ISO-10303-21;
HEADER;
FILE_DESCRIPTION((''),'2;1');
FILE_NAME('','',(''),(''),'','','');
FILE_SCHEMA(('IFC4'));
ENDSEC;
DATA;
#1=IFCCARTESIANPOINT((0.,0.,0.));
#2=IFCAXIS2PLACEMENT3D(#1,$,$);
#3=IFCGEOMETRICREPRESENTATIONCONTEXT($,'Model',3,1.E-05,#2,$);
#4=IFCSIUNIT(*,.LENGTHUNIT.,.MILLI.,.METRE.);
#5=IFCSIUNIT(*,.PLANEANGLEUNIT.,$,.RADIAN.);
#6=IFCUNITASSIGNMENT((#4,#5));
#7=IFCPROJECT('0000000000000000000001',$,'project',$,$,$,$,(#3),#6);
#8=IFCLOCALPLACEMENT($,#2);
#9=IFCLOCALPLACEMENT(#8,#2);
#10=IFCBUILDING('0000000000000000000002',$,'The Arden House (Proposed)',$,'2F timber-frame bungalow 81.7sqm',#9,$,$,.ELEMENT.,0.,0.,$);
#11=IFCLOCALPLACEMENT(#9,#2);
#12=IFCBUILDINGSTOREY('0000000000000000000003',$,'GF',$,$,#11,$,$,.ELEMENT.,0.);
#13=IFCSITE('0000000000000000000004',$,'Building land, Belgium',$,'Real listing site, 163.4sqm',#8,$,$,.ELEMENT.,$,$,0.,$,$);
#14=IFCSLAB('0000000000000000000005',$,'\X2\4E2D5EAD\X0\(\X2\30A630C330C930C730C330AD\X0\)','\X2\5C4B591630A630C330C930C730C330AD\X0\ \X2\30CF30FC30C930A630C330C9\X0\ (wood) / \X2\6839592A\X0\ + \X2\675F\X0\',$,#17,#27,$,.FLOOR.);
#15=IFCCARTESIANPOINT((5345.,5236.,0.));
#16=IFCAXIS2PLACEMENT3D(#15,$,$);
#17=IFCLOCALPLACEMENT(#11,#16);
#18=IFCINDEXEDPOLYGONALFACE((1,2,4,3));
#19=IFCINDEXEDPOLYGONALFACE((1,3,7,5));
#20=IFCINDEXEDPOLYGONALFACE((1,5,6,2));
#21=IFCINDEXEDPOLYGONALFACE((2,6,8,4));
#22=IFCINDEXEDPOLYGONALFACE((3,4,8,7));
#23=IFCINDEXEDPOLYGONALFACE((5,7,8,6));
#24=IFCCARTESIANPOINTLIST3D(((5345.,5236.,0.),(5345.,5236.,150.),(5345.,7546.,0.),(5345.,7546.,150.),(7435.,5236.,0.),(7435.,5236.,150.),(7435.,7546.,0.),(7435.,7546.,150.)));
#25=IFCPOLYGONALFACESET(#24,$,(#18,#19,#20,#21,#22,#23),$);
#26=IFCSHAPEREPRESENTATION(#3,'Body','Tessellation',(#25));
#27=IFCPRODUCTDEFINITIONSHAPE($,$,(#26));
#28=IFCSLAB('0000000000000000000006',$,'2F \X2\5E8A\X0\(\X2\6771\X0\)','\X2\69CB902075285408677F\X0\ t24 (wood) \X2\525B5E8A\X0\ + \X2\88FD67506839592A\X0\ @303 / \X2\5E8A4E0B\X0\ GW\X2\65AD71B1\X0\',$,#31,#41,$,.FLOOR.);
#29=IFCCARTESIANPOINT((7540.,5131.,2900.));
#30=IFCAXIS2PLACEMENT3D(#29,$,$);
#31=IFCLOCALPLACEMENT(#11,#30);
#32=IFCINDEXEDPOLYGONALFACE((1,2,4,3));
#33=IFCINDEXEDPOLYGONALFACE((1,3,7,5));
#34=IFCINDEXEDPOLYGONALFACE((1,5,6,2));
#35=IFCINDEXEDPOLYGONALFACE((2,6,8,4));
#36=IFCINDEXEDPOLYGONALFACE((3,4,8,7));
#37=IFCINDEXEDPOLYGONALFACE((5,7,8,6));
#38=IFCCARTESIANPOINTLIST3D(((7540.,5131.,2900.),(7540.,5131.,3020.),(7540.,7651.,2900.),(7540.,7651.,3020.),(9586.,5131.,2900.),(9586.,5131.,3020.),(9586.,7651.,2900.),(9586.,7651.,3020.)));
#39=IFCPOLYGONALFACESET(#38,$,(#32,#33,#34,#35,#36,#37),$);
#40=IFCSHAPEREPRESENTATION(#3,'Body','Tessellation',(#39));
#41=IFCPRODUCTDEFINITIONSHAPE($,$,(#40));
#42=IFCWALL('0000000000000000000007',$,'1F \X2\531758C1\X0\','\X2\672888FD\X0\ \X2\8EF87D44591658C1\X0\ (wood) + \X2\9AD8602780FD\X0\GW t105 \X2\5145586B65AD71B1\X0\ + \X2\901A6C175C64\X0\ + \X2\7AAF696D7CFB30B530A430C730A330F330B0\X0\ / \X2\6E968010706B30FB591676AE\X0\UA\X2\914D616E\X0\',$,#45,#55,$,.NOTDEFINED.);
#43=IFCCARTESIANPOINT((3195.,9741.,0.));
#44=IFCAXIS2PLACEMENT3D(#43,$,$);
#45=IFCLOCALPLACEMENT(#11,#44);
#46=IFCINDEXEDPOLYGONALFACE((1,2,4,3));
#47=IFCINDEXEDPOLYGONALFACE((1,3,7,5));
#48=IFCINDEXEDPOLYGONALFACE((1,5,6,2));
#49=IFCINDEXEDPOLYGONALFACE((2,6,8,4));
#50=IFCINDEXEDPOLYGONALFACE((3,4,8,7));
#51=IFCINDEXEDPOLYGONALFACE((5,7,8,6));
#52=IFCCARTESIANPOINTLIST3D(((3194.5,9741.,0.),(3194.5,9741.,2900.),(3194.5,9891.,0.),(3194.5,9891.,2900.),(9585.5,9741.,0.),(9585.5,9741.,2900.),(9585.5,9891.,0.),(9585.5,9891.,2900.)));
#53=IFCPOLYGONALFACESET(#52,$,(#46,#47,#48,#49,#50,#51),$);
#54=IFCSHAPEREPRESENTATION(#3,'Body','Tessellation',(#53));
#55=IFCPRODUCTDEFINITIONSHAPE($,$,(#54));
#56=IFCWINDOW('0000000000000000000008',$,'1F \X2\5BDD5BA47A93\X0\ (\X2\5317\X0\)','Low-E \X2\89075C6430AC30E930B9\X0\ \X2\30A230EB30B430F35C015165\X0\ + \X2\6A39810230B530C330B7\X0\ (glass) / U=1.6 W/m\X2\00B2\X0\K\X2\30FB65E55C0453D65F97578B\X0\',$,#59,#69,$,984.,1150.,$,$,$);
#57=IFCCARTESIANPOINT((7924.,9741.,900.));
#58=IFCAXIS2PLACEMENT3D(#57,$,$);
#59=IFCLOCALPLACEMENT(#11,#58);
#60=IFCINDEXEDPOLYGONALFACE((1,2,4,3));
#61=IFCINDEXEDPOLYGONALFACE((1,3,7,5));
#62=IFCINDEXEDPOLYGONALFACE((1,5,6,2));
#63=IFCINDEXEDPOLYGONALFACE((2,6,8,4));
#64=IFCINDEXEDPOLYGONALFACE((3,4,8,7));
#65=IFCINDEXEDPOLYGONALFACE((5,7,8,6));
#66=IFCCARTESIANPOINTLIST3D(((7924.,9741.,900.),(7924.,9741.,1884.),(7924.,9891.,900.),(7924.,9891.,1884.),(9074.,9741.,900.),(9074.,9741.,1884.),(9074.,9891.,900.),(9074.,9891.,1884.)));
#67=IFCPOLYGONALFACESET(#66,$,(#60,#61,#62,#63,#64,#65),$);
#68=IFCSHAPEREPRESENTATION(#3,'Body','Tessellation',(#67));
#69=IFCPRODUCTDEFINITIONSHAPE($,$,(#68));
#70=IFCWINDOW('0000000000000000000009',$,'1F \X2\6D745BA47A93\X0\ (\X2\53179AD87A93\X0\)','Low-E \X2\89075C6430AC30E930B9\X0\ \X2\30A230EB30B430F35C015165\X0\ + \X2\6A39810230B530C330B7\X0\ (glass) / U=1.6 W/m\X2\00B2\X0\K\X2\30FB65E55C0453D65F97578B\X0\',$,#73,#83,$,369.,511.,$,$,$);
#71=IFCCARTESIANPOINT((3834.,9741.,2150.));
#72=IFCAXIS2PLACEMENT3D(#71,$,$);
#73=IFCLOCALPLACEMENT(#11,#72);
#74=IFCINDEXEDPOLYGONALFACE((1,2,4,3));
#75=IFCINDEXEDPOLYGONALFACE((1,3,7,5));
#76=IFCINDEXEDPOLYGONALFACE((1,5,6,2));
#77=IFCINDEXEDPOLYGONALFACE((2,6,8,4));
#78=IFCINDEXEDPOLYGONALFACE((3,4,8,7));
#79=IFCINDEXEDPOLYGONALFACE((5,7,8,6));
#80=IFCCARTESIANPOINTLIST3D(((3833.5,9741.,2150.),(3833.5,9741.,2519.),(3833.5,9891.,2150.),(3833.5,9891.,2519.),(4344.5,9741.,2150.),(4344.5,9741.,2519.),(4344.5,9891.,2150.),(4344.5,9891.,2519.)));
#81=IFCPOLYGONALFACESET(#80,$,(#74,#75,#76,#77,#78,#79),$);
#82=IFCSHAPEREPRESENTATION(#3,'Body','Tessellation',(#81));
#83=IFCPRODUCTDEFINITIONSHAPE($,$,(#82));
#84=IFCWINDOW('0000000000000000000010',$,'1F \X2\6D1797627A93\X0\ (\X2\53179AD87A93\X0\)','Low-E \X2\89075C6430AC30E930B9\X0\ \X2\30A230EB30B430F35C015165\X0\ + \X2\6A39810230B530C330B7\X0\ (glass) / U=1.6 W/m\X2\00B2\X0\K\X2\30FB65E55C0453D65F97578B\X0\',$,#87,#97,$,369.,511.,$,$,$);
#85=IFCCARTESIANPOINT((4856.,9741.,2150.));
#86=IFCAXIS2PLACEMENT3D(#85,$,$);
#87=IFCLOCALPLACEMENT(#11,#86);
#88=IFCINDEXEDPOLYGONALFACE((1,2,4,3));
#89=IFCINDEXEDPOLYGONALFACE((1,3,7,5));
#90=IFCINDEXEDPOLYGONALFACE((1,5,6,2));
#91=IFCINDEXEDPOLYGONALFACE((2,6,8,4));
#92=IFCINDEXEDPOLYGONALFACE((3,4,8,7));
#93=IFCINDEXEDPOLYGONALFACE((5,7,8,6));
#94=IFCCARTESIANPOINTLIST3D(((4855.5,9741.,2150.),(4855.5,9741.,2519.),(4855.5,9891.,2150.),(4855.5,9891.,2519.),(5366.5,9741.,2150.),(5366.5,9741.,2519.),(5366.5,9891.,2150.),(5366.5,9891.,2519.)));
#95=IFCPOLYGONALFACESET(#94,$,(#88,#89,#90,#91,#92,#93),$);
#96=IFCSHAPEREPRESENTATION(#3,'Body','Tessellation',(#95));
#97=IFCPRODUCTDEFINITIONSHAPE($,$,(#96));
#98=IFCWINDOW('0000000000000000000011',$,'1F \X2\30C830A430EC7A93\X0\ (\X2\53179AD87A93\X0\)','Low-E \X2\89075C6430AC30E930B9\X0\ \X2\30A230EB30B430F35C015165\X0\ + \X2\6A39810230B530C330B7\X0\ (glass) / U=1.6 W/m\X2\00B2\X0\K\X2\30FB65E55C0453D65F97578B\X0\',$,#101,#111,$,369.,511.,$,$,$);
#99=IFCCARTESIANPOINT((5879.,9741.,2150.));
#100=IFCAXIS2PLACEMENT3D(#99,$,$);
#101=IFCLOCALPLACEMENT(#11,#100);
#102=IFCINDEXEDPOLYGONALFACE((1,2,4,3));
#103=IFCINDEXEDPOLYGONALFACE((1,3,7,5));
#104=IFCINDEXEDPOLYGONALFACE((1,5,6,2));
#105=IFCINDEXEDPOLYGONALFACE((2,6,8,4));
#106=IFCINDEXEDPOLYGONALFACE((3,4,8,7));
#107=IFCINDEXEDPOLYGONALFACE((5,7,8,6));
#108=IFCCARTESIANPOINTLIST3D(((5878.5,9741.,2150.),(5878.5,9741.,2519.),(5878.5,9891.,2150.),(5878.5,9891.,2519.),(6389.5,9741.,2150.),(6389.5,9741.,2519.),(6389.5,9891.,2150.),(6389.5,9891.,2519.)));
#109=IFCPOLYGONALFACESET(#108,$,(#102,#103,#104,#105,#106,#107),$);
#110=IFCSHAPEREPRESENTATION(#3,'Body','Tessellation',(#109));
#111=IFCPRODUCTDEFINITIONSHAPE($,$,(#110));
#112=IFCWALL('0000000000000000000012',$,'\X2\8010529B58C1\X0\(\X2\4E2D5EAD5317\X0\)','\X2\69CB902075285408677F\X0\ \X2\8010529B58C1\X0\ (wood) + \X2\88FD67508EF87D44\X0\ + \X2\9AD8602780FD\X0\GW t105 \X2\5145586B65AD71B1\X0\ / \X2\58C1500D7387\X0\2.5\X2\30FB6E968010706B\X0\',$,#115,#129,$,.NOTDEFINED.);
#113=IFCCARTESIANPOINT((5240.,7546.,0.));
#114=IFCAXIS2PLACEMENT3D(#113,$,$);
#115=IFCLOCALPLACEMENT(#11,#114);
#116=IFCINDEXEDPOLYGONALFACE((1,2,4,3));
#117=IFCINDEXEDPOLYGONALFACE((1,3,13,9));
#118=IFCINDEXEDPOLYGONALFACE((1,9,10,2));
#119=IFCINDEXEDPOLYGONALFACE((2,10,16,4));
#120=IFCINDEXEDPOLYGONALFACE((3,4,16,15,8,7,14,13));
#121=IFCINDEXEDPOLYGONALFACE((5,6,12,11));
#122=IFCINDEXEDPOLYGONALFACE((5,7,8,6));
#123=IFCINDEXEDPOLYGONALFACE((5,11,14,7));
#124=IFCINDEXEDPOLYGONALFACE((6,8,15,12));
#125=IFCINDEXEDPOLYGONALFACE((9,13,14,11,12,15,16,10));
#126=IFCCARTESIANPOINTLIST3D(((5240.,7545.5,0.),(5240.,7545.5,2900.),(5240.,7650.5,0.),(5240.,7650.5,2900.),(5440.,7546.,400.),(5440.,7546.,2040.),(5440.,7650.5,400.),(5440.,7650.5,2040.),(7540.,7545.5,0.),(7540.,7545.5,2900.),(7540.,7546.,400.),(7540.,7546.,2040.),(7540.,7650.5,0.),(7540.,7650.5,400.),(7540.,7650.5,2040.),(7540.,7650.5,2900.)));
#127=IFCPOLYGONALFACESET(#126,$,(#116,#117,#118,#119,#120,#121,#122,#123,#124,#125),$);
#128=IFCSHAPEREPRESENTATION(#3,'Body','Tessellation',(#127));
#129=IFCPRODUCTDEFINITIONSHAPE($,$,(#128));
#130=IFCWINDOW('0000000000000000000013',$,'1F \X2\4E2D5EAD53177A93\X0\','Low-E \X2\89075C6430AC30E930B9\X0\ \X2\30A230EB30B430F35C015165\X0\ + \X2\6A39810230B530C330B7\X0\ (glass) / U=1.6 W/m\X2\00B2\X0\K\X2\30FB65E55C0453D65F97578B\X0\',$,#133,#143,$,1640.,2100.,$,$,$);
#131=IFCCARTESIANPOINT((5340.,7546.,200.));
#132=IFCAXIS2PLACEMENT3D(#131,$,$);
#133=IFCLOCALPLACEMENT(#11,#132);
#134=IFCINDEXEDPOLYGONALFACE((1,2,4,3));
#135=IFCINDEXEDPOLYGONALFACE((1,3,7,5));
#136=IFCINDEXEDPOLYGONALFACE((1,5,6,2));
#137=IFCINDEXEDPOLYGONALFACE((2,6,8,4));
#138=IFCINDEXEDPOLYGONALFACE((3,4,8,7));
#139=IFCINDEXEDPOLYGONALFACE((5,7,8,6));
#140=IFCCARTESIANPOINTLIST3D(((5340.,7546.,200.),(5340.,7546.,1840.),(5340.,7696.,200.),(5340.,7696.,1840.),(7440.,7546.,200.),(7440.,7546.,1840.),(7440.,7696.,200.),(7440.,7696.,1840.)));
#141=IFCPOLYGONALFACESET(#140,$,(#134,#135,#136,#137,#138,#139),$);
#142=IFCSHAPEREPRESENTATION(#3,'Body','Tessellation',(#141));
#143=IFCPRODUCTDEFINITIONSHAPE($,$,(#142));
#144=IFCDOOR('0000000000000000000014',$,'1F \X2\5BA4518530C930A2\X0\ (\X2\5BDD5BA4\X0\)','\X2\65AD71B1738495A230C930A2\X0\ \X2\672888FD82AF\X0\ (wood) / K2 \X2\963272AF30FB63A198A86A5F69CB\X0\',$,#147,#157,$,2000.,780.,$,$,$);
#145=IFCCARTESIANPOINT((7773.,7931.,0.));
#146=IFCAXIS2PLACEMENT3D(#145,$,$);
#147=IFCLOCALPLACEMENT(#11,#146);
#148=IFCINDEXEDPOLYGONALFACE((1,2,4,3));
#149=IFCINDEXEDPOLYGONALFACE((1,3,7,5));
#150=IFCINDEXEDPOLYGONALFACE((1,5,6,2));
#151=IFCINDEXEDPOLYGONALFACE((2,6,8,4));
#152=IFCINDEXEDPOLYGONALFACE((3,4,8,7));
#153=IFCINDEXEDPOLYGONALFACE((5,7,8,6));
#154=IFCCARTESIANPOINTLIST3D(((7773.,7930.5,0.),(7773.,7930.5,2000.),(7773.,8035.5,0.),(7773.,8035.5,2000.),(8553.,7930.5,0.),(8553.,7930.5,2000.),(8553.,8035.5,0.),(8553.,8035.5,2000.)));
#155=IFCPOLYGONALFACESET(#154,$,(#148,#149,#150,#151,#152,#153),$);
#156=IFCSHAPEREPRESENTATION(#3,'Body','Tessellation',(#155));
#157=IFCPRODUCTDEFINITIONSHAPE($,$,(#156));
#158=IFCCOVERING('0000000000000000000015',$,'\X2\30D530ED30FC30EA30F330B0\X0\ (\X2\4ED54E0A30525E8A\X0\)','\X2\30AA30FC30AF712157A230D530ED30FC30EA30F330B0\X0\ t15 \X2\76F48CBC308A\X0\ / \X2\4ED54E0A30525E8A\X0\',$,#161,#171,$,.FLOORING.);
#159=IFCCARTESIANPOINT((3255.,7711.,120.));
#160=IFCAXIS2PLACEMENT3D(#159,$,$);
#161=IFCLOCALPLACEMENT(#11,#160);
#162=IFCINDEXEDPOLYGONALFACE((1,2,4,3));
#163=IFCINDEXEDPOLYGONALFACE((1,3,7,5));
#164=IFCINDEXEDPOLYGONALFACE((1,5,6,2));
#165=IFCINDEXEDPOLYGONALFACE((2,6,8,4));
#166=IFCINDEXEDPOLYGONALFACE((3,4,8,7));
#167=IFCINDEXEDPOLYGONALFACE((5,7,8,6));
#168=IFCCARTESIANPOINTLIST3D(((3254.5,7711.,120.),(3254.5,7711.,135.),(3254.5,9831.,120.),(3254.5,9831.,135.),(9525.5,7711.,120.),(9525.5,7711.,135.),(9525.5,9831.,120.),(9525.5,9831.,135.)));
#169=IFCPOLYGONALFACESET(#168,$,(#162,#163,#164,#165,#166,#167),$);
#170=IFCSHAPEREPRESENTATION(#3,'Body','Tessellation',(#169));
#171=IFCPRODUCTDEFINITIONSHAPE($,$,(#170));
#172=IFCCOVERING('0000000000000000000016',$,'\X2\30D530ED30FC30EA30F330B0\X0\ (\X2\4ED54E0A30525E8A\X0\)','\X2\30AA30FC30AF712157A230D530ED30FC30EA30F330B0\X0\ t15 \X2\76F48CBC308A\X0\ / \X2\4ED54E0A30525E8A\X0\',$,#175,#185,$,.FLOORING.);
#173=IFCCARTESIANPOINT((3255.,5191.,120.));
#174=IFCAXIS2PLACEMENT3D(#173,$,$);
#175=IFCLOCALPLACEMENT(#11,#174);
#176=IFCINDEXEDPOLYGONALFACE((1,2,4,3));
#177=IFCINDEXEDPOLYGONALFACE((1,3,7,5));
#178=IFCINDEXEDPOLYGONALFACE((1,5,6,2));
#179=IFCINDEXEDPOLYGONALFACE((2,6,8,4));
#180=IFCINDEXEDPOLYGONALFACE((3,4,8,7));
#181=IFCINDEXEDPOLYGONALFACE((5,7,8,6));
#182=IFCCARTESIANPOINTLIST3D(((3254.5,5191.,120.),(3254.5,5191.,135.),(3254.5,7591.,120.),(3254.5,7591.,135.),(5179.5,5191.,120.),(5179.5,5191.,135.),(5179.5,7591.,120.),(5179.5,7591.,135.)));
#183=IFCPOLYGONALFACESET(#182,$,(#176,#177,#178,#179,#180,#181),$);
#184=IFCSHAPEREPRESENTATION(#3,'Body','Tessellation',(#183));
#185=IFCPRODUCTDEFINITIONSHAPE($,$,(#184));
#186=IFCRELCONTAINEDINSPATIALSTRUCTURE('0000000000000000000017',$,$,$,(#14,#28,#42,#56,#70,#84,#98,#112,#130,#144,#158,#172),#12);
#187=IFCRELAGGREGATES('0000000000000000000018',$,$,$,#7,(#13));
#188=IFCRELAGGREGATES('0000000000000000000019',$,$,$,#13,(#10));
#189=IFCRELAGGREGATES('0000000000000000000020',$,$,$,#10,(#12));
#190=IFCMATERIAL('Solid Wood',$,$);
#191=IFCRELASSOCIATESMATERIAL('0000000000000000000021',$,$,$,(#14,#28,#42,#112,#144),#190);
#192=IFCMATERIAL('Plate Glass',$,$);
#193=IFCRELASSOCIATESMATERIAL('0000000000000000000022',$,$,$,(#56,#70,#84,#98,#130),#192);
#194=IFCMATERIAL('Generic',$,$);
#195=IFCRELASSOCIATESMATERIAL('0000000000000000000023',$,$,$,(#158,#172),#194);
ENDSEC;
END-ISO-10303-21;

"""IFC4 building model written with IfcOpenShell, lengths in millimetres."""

from ifc_helpers import new_model, si_unit, frame, frame_2d, origin, place, context, project, spatial, rectangle, extrude, material, element, fill, save


model = new_model("IFC4")

# Units and contexts
model_context = context("Model", 3, precision=1e-05, world=origin())
ifc_project = project(units=[si_unit("LENGTHUNIT", "METRE", prefix="MILLI"), si_unit("PLANEANGLEUNIT", "RADIAN")], contexts=[model_context])

# Site, building, storey
site_placement = place(None, origin())
site = spatial("IfcSite", under=ifc_project, at=site_placement, Name="Building land, Belgium", ObjectType="Real listing site, 163.4sqm", CompositionType="ELEMENT", RefElevation=0.0)
building_placement = place(site_placement, origin())
building = spatial("IfcBuilding", under=site, at=building_placement, Name="The Arden House (Proposed)", ObjectType="2F timber-frame bungalow 81.7sqm", CompositionType="ELEMENT", ElevationOfRefHeight=0.0, ElevationOfTerrain=0.0)
storey_placement = place(building_placement, origin())
storey = spatial("IfcBuildingStorey", under=building, at=storey_placement, Name="GF", CompositionType="ELEMENT", Elevation=0.0)

# Slabs
ifc_material_1 = material(Name="Solid Wood")
slab_1_placement = place(storey_placement, frame((5345.0, 5236.0, 0.0)))
element("IfcSlab", 1, at=slab_1_placement, inside=storey, material=ifc_material_1, Name="中庭(ウッドデッキ)", Description="屋外ウッドデッキ ハードウッド (wood) / 根太 + 束", PredefinedType="FLOOR", context=model_context, shape_type="SweptSolid", body=[
    extrude(rectangle(XDim=2090.0, YDim=2310.0, at=frame_2d((1045.0, 1155.0))), frame((5345.0, 5236.0, 0.0)), (0.0, 0.0, 1.0), 150.0),
])
slab_2_placement = place(storey_placement, frame((7540.0, 5131.0, 2900.0)))
element("IfcSlab", 2, at=slab_2_placement, inside=storey, material=ifc_material_1, Name="2F 床(東)", Description="構造用合板 t24 (wood) 剛床 + 製材根太 @303 / 床下 GW断熱", PredefinedType="FLOOR", context=model_context, shape_type="SweptSolid", body=[
    extrude(rectangle(XDim=2046.0, YDim=2520.0, at=frame_2d((1023.0, 1260.0))), frame((7540.0, 5131.0, 2900.0)), (0.0, 0.0, 1.0), 120.0),
])

# Wall, openings, windows
wall_1_placement = place(storey_placement, frame((3195.0, 9741.0, 0.0)))
wall_1 = element("IfcWall", 3, at=wall_1_placement, inside=storey, material=ifc_material_1, Name="1F 北壁", Description="木製 軸組外壁 (wood) + 高性能GW t105 充填断熱 + 通気層 + 窯業系サイディング / 準耐火・外皮UA配慮", PredefinedType="NOTDEFINED", context=model_context, shape_type="SweptSolid", body=[
    extrude(rectangle(XDim=6391.0, YDim=150.0, at=frame_2d((3195.0, 75.0))), frame((3195.0, 9741.0, 0.0)), (0.0, 0.0, 1.0), 2900.0),
])
opening_1_placement = place(storey_placement, frame((7924.0, 9741.0, 900.0)))
opening_1 = element("IfcOpeningElement", 4, at=opening_1_placement, cuts=wall_1, PredefinedType="NOTDEFINED", context=model_context, shape_type="SweptSolid", body=[
    extrude(rectangle(XDim=1150.0, YDim=150.0, at=frame_2d((575.0, 75.0))), frame((7924.0, 9741.0, 900.0)), (0.0, 0.0, 1.0), 984.0),
])
opening_2_placement = place(storey_placement, frame((3834.0, 9741.0, 2150.0)))
opening_2 = element("IfcOpeningElement", 5, at=opening_2_placement, cuts=wall_1, PredefinedType="NOTDEFINED", context=model_context, shape_type="SweptSolid", body=[
    extrude(rectangle(XDim=511.0, YDim=150.0, at=frame_2d((255.0, 75.0))), frame((3834.0, 9741.0, 2150.0)), (0.0, 0.0, 1.0), 369.0),
])
opening_3_placement = place(storey_placement, frame((4856.0, 9741.0, 2150.0)))
opening_3 = element("IfcOpeningElement", 6, at=opening_3_placement, cuts=wall_1, PredefinedType="NOTDEFINED", context=model_context, shape_type="SweptSolid", body=[
    extrude(rectangle(XDim=511.0, YDim=150.0, at=frame_2d((255.0, 75.0))), frame((4856.0, 9741.0, 2150.0)), (0.0, 0.0, 1.0), 369.0),
])
opening_4_placement = place(storey_placement, frame((5879.0, 9741.0, 2150.0)))
opening_4 = element("IfcOpeningElement", 7, at=opening_4_placement, cuts=wall_1, PredefinedType="NOTDEFINED", context=model_context, shape_type="SweptSolid", body=[
    extrude(rectangle(XDim=511.0, YDim=150.0, at=frame_2d((255.0, 75.0))), frame((5879.0, 9741.0, 2150.0)), (0.0, 0.0, 1.0), 369.0),
])
ifc_material_2 = material(Name="Plate Glass")
window_1_placement = place(storey_placement, frame((7924.0, 9741.0, 900.0)))
window_1 = element("IfcWindow", 8, at=window_1_placement, inside=storey, material=ifc_material_2, Name="1F 寝室窓 (北)", Description="Low-E 複層ガラス アルゴン封入 + 樹脂サッシ (glass) / U=1.6 W/m²K・日射取得型", OverallHeight=984.0, OverallWidth=1150.0, context=model_context, shape_type="SweptSolid", body=[
    extrude(rectangle(XDim=1150.0, YDim=150.0, at=frame_2d((575.0, 75.0))), frame((7924.0, 9741.0, 900.0)), (0.0, 0.0, 1.0), 984.0),
])
fill(opening_1, window_1)
window_2_placement = place(storey_placement, frame((3834.0, 9741.0, 2150.0)))
window_2 = element("IfcWindow", 9, at=window_2_placement, inside=storey, material=ifc_material_2, Name="1F 浴室窓 (北高窓)", Description="Low-E 複層ガラス アルゴン封入 + 樹脂サッシ (glass) / U=1.6 W/m²K・日射取得型", OverallHeight=369.0, OverallWidth=511.0, context=model_context, shape_type="SweptSolid", body=[
    extrude(rectangle(XDim=511.0, YDim=150.0, at=frame_2d((255.0, 75.0))), frame((3834.0, 9741.0, 2150.0)), (0.0, 0.0, 1.0), 369.0),
])
fill(opening_2, window_2)
window_3_placement = place(storey_placement, frame((4856.0, 9741.0, 2150.0)))
window_3 = element("IfcWindow", 10, at=window_3_placement, inside=storey, material=ifc_material_2, Name="1F 洗面窓 (北高窓)", Description="Low-E 複層ガラス アルゴン封入 + 樹脂サッシ (glass) / U=1.6 W/m²K・日射取得型", OverallHeight=369.0, OverallWidth=511.0, context=model_context, shape_type="SweptSolid", body=[
    extrude(rectangle(XDim=511.0, YDim=150.0, at=frame_2d((255.0, 75.0))), frame((4856.0, 9741.0, 2150.0)), (0.0, 0.0, 1.0), 369.0),
])
fill(opening_3, window_3)
window_4_placement = place(storey_placement, frame((5879.0, 9741.0, 2150.0)))
window_4 = element("IfcWindow", 11, at=window_4_placement, inside=storey, material=ifc_material_2, Name="1F トイレ窓 (北高窓)", Description="Low-E 複層ガラス アルゴン封入 + 樹脂サッシ (glass) / U=1.6 W/m²K・日射取得型", OverallHeight=369.0, OverallWidth=511.0, context=model_context, shape_type="SweptSolid", body=[
    extrude(rectangle(XDim=511.0, YDim=150.0, at=frame_2d((255.0, 75.0))), frame((5879.0, 9741.0, 2150.0)), (0.0, 0.0, 1.0), 369.0),
])
fill(opening_4, window_4)

# Wall, opening, window
wall_2_placement = place(storey_placement, frame((5240.0, 7546.0, 0.0)))
wall_2 = element("IfcWall", 12, at=wall_2_placement, inside=storey, material=ifc_material_1, Name="耐力壁(中庭北)", Description="構造用合板 耐力壁 (wood) + 製材軸組 + 高性能GW t105 充填断熱 / 壁倍率2.5・準耐火", PredefinedType="NOTDEFINED", context=model_context, shape_type="SweptSolid", body=[
    extrude(rectangle(XDim=2300.0, YDim=105.0, at=frame_2d((1150.0, 52.0))), frame((5240.0, 7546.0, 0.0)), (0.0, 0.0, 1.0), 2900.0),
])
opening_5_placement = place(storey_placement, frame((5340.0, 7546.0, 200.0)))
opening_5 = element("IfcOpeningElement", 13, at=opening_5_placement, cuts=wall_2, PredefinedType="NOTDEFINED", context=model_context, shape_type="SweptSolid", body=[
    extrude(rectangle(XDim=2100.0, YDim=150.0, at=frame_2d((1050.0, 75.0))), frame((5340.0, 7546.0, 200.0)), (0.0, 0.0, 1.0), 1640.0),
])
window_5_placement = place(storey_placement, frame((5340.0, 7546.0, 200.0)))
window_5 = element("IfcWindow", 14, at=window_5_placement, inside=storey, material=ifc_material_2, Name="1F 中庭北窓", Description="Low-E 複層ガラス アルゴン封入 + 樹脂サッシ (glass) / U=1.6 W/m²K・日射取得型", OverallHeight=1640.0, OverallWidth=2100.0, context=model_context, shape_type="SweptSolid", body=[
    extrude(rectangle(XDim=2100.0, YDim=150.0, at=frame_2d((1050.0, 75.0))), frame((5340.0, 7546.0, 200.0)), (0.0, 0.0, 1.0), 1640.0),
])
fill(opening_5, window_5)

# Door
door_1_placement = place(storey_placement, frame((7773.0, 7931.0, 0.0)))
element("IfcDoor", 15, at=door_1_placement, inside=storey, material=ifc_material_1, Name="1F 室内ドア (寝室)", Description="断熱玄関ドア 木製芯 (wood) / K2 防犯・採風機構", OverallHeight=2000.0, OverallWidth=780.0, context=model_context, shape_type="SweptSolid", body=[
    extrude(rectangle(XDim=780.0, YDim=105.0, at=frame_2d((390.0, 52.0))), frame((7773.0, 7931.0, 0.0)), (0.0, 0.0, 1.0), 2000.0),
])

# Coverings
ifc_material_3 = material(Name="Generic")
covering_1_placement = place(storey_placement, frame((3255.0, 7711.0, 120.0)))
element("IfcCovering", 16, at=covering_1_placement, inside=storey, material=ifc_material_3, Name="フローリング (仕上げ床)", Description="オーク無垢フローリング t15 直貼り / 仕上げ床", PredefinedType="FLOORING", context=model_context, shape_type="SweptSolid", body=[
    extrude(rectangle(XDim=6271.0, YDim=2120.0, at=frame_2d((3135.0, 1060.0))), frame((3255.0, 7711.0, 120.0)), (0.0, 0.0, 1.0), 15.0),
])
covering_2_placement = place(storey_placement, frame((3255.0, 5191.0, 120.0)))
element("IfcCovering", 17, at=covering_2_placement, inside=storey, material=ifc_material_3, Name="フローリング (仕上げ床)", Description="オーク無垢フローリング t15 直貼り / 仕上げ床", PredefinedType="FLOORING", context=model_context, shape_type="SweptSolid", body=[
    extrude(rectangle(XDim=1925.0, YDim=2400.0, at=frame_2d((962.0, 1200.0))), frame((3255.0, 5191.0, 120.0)), (0.0, 0.0, 1.0), 15.0),
])

save(model, "model.ifc")
